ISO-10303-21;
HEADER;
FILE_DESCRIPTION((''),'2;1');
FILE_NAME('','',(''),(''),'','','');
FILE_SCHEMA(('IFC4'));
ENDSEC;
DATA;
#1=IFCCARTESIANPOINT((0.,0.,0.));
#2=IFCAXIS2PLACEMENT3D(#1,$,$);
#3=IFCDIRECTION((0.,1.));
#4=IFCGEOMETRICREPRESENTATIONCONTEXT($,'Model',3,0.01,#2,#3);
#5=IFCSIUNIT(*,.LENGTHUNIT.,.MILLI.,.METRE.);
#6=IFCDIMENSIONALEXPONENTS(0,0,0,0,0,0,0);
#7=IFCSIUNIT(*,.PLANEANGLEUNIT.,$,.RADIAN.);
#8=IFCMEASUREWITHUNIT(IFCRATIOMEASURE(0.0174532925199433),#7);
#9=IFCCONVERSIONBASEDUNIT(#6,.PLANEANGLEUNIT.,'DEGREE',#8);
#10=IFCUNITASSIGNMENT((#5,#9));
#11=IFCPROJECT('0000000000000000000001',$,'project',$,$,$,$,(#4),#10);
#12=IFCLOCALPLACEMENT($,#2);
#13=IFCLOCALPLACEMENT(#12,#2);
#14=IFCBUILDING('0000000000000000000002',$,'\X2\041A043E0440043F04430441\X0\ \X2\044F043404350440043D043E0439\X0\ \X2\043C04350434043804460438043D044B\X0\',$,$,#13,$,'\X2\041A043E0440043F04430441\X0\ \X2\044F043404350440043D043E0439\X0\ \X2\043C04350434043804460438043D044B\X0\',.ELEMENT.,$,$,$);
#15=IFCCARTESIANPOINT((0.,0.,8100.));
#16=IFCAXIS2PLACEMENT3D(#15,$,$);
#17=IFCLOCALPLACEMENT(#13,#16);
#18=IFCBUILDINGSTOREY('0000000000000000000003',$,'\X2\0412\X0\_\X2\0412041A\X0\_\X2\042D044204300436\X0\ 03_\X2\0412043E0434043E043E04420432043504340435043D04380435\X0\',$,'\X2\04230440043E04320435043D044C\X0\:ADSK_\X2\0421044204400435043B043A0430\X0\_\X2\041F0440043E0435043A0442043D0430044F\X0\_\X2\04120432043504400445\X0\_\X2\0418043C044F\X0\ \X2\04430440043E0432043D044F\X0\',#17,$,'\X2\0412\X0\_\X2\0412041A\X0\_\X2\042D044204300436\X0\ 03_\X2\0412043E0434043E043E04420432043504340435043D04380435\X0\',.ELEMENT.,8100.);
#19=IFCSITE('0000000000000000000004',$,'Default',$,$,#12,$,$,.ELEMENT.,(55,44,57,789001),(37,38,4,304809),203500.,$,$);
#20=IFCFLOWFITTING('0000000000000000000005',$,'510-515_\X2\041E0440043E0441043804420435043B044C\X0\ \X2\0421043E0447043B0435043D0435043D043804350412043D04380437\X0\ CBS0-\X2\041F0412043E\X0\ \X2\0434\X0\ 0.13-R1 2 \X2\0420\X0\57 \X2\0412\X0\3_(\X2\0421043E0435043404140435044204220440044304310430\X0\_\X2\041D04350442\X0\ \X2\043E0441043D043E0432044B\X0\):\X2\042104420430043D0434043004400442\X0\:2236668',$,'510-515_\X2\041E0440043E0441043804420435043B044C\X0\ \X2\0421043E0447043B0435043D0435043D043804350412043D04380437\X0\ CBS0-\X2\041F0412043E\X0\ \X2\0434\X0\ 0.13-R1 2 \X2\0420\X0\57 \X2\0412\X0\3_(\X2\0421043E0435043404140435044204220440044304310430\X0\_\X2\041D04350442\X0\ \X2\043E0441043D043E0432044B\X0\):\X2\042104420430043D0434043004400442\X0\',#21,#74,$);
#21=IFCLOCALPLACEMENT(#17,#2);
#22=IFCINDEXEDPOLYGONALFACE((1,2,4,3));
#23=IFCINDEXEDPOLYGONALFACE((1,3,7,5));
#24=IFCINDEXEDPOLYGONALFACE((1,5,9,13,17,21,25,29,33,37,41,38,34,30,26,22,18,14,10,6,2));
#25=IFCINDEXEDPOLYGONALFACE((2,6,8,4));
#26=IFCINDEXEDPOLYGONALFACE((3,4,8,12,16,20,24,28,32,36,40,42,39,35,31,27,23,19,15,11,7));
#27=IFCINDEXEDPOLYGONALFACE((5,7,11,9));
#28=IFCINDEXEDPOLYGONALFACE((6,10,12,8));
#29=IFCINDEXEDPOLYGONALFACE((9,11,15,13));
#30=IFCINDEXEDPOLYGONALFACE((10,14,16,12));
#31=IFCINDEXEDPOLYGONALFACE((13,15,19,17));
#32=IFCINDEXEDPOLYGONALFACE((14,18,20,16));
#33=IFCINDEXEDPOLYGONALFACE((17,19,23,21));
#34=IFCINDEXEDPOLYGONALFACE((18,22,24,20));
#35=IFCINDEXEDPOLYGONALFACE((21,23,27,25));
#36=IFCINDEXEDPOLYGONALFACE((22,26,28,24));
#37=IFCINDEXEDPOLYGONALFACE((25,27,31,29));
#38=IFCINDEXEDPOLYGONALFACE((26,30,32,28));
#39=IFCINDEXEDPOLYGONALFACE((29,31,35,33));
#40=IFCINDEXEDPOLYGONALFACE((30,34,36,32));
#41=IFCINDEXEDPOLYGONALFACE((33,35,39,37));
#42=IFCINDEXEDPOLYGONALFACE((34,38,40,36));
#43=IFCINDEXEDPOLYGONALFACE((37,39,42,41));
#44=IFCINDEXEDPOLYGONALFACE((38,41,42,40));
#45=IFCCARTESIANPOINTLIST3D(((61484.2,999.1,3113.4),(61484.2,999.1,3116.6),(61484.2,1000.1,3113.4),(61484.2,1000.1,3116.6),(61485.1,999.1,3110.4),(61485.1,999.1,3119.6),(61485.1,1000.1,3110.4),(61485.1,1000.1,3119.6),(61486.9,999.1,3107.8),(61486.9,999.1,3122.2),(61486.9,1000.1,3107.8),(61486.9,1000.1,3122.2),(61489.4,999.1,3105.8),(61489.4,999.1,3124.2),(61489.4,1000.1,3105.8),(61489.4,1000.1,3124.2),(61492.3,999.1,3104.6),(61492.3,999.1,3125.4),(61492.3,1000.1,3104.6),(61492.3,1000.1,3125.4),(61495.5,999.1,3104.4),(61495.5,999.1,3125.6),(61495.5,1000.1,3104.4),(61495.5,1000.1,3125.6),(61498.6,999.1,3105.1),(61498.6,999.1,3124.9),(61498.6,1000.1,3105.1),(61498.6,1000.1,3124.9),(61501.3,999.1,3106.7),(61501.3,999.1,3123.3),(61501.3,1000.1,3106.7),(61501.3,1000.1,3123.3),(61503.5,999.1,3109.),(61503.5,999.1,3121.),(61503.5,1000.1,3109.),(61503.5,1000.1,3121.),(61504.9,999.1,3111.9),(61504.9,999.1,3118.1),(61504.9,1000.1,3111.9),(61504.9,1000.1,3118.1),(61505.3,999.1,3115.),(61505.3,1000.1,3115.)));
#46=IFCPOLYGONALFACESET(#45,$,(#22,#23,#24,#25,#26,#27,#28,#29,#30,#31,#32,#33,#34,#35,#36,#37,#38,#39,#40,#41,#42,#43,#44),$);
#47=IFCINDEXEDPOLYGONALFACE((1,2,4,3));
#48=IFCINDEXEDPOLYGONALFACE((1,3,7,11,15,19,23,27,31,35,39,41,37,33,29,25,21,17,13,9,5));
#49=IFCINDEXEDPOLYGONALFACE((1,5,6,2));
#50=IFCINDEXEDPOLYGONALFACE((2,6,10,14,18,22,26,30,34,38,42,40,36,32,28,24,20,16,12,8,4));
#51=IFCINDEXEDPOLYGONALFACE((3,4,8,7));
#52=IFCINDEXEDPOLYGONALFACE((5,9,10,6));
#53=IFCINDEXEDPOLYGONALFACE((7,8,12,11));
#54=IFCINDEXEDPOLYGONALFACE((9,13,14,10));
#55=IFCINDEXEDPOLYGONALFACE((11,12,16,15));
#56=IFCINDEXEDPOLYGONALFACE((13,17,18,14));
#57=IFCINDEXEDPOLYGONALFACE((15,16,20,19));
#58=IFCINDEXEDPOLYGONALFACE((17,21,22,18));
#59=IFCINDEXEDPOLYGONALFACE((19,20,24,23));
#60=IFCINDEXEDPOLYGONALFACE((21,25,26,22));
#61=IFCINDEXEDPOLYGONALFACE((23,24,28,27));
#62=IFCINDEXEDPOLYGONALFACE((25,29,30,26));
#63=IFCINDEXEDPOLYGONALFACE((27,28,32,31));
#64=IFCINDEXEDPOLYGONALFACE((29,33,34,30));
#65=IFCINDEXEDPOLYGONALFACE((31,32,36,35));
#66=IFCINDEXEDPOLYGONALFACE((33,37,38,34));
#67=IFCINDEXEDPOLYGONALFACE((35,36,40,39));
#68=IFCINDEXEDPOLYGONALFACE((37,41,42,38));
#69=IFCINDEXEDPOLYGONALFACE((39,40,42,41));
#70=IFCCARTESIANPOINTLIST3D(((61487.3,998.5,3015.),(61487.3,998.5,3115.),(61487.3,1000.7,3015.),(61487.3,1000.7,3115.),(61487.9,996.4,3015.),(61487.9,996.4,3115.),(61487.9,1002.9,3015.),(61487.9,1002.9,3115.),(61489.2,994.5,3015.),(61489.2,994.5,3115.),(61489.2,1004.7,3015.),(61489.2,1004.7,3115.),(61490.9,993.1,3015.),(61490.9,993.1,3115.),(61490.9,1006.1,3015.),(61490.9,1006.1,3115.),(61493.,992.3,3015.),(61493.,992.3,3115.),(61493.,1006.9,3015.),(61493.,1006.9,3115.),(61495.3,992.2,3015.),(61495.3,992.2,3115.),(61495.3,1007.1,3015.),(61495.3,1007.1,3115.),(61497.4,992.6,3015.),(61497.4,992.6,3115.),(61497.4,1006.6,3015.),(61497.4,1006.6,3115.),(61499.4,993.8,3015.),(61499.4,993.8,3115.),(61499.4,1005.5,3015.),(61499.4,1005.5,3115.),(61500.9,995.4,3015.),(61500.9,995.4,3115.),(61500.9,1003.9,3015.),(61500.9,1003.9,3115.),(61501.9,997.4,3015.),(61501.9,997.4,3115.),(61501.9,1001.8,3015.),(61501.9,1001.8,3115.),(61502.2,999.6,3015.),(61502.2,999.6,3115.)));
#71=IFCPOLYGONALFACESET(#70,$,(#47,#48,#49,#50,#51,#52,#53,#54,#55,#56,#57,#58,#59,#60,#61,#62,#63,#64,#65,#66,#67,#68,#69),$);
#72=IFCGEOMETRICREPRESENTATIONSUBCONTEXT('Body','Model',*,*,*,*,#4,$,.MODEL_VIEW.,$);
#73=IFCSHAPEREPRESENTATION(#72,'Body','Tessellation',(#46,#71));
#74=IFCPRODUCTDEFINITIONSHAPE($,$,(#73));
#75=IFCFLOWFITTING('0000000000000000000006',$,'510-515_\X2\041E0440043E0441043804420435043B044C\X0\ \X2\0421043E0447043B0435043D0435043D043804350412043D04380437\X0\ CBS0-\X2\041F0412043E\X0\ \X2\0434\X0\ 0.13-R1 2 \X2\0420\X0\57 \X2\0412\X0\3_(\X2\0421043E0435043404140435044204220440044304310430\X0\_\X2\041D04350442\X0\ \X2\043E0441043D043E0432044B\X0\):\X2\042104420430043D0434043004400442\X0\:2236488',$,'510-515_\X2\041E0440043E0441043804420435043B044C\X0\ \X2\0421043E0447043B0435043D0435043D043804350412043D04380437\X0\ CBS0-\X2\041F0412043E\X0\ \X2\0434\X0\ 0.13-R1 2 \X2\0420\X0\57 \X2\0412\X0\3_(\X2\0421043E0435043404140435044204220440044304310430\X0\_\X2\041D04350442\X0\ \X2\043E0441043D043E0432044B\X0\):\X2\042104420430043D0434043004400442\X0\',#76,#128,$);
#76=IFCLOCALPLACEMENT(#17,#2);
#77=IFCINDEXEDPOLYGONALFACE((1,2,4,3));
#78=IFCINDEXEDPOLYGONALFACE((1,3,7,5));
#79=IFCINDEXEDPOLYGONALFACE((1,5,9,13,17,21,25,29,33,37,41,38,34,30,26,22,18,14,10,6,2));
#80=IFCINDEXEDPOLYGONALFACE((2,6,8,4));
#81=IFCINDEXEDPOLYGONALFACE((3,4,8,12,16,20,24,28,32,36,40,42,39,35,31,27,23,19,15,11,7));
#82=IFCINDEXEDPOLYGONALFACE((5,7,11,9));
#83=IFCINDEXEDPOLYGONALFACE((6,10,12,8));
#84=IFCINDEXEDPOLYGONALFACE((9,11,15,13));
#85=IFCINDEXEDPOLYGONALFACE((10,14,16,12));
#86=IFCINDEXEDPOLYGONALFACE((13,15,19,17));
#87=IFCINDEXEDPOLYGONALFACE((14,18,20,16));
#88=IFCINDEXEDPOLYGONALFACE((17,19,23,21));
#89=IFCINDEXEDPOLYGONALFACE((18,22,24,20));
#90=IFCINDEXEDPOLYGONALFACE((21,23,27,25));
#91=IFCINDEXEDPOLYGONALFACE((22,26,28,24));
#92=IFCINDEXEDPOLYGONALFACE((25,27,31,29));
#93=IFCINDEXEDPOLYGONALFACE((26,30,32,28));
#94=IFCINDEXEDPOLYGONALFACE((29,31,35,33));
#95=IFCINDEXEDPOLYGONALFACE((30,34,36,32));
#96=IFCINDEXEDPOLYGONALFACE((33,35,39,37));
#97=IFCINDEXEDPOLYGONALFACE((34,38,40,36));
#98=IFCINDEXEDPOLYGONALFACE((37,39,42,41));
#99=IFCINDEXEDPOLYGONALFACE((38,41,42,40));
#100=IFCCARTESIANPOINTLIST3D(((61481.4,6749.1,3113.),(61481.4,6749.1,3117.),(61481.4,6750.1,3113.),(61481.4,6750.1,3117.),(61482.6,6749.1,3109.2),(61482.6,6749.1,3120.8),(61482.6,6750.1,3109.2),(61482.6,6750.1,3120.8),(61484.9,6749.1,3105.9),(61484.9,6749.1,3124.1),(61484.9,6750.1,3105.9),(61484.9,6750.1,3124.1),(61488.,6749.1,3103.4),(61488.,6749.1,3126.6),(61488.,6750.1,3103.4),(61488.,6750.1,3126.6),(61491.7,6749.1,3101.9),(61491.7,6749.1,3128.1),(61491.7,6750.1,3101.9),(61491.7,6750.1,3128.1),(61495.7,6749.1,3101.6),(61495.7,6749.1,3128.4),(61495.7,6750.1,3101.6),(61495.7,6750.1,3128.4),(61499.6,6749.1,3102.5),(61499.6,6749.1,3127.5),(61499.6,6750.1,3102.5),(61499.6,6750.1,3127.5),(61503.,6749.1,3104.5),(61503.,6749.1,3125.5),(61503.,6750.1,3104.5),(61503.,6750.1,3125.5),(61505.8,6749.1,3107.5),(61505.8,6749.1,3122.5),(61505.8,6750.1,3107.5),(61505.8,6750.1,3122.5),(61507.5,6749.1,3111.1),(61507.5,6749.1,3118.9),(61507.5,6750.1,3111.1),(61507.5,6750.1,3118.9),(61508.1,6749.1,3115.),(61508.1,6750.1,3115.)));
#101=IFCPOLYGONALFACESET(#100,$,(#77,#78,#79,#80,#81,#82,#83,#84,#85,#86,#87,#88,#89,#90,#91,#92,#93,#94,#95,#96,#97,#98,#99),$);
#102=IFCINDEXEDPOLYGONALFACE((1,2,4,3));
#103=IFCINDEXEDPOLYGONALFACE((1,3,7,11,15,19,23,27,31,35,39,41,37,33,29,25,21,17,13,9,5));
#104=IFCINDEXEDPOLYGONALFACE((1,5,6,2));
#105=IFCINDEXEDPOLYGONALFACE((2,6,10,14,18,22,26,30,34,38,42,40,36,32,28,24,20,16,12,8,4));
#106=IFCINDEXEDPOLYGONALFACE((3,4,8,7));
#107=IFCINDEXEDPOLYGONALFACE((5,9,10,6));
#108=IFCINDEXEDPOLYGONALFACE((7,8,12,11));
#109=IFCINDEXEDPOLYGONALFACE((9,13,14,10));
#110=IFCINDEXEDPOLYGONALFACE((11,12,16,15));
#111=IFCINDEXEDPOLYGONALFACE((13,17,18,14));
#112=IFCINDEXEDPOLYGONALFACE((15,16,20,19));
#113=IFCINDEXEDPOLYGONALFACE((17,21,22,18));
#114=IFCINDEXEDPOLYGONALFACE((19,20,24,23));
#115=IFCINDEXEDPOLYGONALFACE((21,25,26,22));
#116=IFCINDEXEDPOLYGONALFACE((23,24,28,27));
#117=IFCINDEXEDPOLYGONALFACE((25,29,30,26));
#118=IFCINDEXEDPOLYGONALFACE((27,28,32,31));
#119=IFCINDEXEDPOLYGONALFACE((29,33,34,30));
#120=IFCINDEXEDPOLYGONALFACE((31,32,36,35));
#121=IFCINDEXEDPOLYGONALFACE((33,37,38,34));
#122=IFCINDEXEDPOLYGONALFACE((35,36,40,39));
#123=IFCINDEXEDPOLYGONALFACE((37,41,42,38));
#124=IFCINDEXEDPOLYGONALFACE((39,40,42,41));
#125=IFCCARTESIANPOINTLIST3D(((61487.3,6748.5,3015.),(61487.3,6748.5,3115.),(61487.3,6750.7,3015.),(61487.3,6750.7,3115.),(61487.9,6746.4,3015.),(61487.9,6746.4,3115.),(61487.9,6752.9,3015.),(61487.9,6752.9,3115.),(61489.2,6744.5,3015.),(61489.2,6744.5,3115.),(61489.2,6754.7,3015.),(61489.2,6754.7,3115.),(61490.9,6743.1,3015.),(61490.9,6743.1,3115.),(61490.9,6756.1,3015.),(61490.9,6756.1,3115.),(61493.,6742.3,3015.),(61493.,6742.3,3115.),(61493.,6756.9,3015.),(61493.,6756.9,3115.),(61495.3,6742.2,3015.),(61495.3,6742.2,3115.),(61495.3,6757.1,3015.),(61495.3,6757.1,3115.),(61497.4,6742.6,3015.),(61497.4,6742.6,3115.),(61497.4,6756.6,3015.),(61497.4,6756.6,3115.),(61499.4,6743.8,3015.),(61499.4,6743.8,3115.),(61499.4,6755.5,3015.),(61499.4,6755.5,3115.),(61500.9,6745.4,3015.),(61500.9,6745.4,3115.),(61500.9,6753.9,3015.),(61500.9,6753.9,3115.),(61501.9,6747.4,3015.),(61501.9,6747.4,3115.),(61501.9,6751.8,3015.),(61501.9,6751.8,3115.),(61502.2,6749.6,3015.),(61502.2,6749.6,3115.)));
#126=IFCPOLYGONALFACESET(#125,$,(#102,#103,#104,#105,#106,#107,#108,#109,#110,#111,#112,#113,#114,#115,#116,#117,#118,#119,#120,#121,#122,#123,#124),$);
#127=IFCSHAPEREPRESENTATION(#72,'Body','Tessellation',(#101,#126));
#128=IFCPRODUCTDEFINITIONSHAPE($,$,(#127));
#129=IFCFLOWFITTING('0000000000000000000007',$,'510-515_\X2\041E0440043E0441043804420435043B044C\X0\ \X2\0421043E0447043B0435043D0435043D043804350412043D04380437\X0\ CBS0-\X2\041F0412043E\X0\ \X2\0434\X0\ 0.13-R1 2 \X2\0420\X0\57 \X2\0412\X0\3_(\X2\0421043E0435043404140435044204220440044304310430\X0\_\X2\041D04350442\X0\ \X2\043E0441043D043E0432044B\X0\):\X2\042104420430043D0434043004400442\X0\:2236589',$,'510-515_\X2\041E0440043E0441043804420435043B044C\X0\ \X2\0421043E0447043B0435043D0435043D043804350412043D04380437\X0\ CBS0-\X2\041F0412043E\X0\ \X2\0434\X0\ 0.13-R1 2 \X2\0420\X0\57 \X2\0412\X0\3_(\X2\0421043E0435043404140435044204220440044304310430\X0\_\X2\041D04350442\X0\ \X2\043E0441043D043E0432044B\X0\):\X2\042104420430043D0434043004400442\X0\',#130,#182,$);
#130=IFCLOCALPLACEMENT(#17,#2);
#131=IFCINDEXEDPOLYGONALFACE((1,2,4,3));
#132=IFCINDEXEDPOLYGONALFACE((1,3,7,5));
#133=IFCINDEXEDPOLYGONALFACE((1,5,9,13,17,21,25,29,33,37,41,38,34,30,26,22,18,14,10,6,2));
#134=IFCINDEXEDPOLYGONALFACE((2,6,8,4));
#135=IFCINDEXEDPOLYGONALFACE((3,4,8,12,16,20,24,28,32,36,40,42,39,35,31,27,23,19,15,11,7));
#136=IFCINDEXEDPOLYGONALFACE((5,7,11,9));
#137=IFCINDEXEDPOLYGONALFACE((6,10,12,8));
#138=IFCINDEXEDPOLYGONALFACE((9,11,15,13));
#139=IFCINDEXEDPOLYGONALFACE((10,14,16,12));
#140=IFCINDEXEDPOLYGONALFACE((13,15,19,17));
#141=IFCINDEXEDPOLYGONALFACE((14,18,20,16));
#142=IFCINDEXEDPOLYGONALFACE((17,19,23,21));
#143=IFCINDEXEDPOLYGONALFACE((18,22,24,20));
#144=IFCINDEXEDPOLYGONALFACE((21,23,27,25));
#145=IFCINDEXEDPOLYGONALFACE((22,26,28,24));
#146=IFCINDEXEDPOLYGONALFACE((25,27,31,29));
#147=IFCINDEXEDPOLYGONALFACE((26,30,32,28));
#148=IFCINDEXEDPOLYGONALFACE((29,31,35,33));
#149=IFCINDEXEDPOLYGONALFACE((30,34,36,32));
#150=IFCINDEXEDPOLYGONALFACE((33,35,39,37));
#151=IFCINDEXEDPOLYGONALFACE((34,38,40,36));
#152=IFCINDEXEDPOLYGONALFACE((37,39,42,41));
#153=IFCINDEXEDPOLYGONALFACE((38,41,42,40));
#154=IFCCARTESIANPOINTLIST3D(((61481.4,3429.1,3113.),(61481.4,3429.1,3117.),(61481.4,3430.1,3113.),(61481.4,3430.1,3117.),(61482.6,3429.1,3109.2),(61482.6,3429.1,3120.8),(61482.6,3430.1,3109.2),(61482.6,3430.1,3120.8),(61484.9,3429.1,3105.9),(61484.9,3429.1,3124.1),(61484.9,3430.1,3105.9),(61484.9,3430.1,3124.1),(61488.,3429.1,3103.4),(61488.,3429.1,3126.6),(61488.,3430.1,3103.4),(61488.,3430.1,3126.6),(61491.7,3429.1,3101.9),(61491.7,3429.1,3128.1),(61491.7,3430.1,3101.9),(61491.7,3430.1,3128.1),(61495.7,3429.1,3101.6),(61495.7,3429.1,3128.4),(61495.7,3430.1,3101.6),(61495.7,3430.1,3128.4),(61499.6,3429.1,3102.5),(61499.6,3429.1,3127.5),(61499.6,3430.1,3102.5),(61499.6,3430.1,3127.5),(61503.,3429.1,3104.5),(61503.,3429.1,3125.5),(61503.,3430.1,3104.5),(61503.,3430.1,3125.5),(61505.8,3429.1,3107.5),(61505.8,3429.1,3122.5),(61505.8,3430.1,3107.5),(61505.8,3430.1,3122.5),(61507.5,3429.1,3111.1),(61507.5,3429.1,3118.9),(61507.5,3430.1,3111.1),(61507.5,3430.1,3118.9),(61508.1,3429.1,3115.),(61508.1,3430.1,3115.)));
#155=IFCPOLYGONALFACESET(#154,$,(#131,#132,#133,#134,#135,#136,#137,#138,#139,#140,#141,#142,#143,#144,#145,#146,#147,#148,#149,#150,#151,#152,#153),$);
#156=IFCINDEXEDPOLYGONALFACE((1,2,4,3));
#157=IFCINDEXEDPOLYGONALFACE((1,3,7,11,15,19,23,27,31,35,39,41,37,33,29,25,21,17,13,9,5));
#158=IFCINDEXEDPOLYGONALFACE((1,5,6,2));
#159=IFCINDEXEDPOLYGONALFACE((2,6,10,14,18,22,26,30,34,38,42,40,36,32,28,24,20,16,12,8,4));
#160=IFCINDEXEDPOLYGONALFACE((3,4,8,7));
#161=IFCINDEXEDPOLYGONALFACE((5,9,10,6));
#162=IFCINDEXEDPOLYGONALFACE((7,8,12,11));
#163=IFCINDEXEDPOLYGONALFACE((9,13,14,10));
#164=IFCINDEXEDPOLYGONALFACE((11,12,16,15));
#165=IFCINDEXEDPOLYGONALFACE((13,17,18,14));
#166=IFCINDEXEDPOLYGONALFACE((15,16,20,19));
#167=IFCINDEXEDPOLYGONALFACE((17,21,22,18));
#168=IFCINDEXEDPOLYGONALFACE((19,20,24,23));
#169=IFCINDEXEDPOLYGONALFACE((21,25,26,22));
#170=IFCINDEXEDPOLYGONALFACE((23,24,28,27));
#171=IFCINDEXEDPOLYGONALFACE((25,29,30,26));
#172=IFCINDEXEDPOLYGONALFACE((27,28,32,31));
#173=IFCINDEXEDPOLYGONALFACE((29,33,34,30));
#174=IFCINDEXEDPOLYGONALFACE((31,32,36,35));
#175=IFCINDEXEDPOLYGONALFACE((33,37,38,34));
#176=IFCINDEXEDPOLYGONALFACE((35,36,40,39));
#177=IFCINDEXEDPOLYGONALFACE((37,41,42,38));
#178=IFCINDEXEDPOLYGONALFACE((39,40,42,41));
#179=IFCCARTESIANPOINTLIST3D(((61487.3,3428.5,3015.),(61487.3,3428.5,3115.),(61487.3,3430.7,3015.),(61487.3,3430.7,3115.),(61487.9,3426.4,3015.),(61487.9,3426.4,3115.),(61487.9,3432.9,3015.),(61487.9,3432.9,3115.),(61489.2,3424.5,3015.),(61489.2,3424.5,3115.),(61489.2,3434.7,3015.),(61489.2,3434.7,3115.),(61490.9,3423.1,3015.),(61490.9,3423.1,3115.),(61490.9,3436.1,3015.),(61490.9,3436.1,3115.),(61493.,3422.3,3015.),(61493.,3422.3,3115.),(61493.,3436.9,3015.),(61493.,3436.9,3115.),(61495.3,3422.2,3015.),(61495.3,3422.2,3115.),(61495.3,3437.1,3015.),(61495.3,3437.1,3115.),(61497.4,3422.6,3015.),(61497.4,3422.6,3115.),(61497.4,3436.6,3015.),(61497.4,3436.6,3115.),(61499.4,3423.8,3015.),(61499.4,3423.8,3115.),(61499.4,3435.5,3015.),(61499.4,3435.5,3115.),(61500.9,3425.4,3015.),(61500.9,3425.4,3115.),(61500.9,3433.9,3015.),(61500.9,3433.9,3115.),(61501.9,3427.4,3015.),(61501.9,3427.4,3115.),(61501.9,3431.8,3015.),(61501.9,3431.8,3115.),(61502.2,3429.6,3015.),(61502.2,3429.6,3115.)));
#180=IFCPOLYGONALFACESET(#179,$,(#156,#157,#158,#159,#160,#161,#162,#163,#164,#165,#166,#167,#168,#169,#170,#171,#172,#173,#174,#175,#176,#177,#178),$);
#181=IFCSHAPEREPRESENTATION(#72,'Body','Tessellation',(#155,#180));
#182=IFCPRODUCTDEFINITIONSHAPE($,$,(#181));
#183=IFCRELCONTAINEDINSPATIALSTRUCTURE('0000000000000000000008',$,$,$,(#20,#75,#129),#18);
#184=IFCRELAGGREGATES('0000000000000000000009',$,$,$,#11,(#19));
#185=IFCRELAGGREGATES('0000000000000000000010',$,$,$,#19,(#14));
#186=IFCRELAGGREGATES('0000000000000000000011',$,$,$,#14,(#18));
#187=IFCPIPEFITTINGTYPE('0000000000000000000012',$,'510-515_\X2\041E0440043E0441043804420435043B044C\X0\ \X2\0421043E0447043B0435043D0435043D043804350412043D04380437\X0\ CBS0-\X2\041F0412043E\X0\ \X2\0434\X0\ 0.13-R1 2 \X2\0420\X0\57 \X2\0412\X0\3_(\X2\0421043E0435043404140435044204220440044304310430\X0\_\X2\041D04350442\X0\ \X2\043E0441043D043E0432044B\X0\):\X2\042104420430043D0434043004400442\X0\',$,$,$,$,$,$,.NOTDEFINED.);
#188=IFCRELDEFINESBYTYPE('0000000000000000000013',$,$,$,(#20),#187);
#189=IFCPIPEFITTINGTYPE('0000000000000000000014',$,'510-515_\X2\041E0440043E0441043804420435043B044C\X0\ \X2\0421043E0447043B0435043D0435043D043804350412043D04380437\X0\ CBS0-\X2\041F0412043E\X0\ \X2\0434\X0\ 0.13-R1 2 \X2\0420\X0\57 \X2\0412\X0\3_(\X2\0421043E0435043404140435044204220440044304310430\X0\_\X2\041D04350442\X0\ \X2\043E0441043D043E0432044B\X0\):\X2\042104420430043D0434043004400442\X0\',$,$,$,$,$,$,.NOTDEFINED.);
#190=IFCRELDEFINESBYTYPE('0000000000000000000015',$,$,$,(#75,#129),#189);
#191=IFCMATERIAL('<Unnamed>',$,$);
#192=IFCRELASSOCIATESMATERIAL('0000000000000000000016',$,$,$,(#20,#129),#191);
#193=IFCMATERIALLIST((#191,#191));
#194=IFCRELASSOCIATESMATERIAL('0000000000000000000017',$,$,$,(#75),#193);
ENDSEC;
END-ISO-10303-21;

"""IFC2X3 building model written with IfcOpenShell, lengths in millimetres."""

from ifc_helpers import new_model, entity, si_unit, converted_unit, direction, frame, origin, origin_2d_with_axis, place, context, subcontext, project, spatial, circle, extrude, source, transform, mapped, material, material_list, type_object, type_shapes, element, save


model = new_model("IFC2X3")

# Units and contexts
model_context = context("Model", 3, precision=0.01, world=origin(), true_north=direction((0.0, 1.0)))
body_context = subcontext(model_context, "Body", "Model", "MODEL_VIEW")
ifc_project = project(units=[si_unit("LENGTHUNIT", "METRE", prefix="MILLI"), converted_unit("PLANEANGLEUNIT", "DEGREE", entity("IfcRatioMeasure", 0.0174532925199433), si_unit("PLANEANGLEUNIT", "RADIAN"), dimensions=[0, 0, 0, 0, 0, 0, 0])], contexts=[model_context])

# Site, building, storey
site_placement = place(None, origin())
site = spatial("IfcSite", under=ifc_project, at=site_placement, Name="Default", CompositionType="ELEMENT", RefLatitude=(55, 44, 57, 789001), RefLongitude=(37, 38, 4, 304809), RefElevation=203500.0)
building_placement = place(site_placement, origin())
building = spatial("IfcBuilding", under=site, at=building_placement, Name="Корпус ядерной медицины", LongName="Корпус ядерной медицины", CompositionType="ELEMENT")
storey_placement = place(building_placement, frame((0.0, 0.0, 8100.0)))
storey = spatial("IfcBuildingStorey", under=building, at=storey_placement, Name="В_ВК_Этаж 03_Водоотведение", ObjectType="Уровень:ADSK_Стрелка_Проектная_Вверх_Имя уровня", LongName="В_ВК_Этаж 03_Водоотведение", CompositionType="ELEMENT", Elevation=8100.0)

# Flow fittings
ifc_material = material(Name="<Unnamed>")
pipe_fitting_type_1 = type_object("IfcPipeFittingType", Name="510-515_Ороситель СочленениеВниз CBS0-ПВо д 0.13-R1 2 Р57 В3_(СоедДетТруба_Нет основы):Стандарт", PredefinedType="NOTDEFINED")
shared_shape_1 = source(origin(), body_context, "Body", "SweptSolid", [
    extrude(circle(Radius=10.7, at=origin_2d_with_axis()), frame((-0.5, 0.0, 0.0), z_axis=(1.0, 0.0, 0.0), x_axis=(0.0, 1.0, 0.0)), (0.0, 0.0, 1.0), 1.0),
    extrude(circle(Radius=7.5, at=origin_2d_with_axis()), frame((0.0, 0.0, -100.0), z_axis=(0.0, 0.0, 1.0), x_axis=(0.0, 1.0, 0.0)), (0.0, 0.0, 1.0), 100.0),
])
type_shapes(pipe_fitting_type_1, [shared_shape_1])
flow_fitting_1_placement = place(storey_placement, frame((61494.7, 999.6, 3115.0), z_axis=(0.0, 0.0, 1.0), x_axis=(0.0, -1.0, 0.0)))
element("IfcFlowFitting", 1, at=flow_fitting_1_placement, inside=storey, type_object=pipe_fitting_type_1, material=ifc_material, Name="510-515_Ороситель СочленениеВниз CBS0-ПВо д 0.13-R1 2 Р57 В3_(СоедДетТруба_Нет основы):Стандарт:2236668", ObjectType="510-515_Ороситель СочленениеВниз CBS0-ПВо д 0.13-R1 2 Р57 В3_(СоедДетТруба_Нет основы):Стандарт", context=body_context, shape_type="MappedRepresentation", body=[
    mapped(shared_shape_1, transform((0.0, 0.0, 0.0), scale=1.0)),
])
ifc_material_list = material_list([ifc_material, ifc_material])
pipe_fitting_type_2 = type_object("IfcPipeFittingType", Name="510-515_Ороситель СочленениеВниз CBS0-ПВо д 0.13-R1 2 Р57 В3_(СоедДетТруба_Нет основы):Стандарт", PredefinedType="NOTDEFINED")
shared_shape_2 = source(origin(), body_context, "Body", "SweptSolid", [
    extrude(circle(Radius=13.4, at=origin_2d_with_axis()), frame((-0.5, 0.0, 0.0), z_axis=(1.0, 0.0, 0.0), x_axis=(0.0, 1.0, 0.0)), (0.0, 0.0, 1.0), 1.0),
    extrude(circle(Radius=7.5, at=origin_2d_with_axis()), frame((0.0, 0.0, -100.0), z_axis=(0.0, 0.0, 1.0), x_axis=(0.0, 1.0, 0.0)), (0.0, 0.0, 1.0), 100.0),
])
type_shapes(pipe_fitting_type_2, [shared_shape_2])
flow_fitting_2_placement = place(storey_placement, frame((61494.7, 6749.6, 3115.0), z_axis=(0.0, 0.0, 1.0), x_axis=(0.0, -1.0, 0.0)))
element("IfcFlowFitting", 2, at=flow_fitting_2_placement, inside=storey, type_object=pipe_fitting_type_2, material=ifc_material_list, Name="510-515_Ороситель СочленениеВниз CBS0-ПВо д 0.13-R1 2 Р57 В3_(СоедДетТруба_Нет основы):Стандарт:2236488", ObjectType="510-515_Ороситель СочленениеВниз CBS0-ПВо д 0.13-R1 2 Р57 В3_(СоедДетТруба_Нет основы):Стандарт", context=body_context, shape_type="MappedRepresentation", body=[
    mapped(shared_shape_2, transform((0.0, 0.0, 0.0), scale=1.0)),
])
flow_fitting_3_placement = place(storey_placement, frame((61494.7, 3429.6, 3115.0), z_axis=(0.0, 0.0, 1.0), x_axis=(0.0, -1.0, 0.0)))
element("IfcFlowFitting", 3, at=flow_fitting_3_placement, inside=storey, type_object=pipe_fitting_type_2, material=ifc_material, Name="510-515_Ороситель СочленениеВниз CBS0-ПВо д 0.13-R1 2 Р57 В3_(СоедДетТруба_Нет основы):Стандарт:2236589", ObjectType="510-515_Ороситель СочленениеВниз CBS0-ПВо д 0.13-R1 2 Р57 В3_(СоедДетТруба_Нет основы):Стандарт", context=body_context, shape_type="MappedRepresentation", body=[
    mapped(shared_shape_2, transform((0.0, 0.0, 0.0), scale=1.0)),
])

save(model, "model.ifc")
